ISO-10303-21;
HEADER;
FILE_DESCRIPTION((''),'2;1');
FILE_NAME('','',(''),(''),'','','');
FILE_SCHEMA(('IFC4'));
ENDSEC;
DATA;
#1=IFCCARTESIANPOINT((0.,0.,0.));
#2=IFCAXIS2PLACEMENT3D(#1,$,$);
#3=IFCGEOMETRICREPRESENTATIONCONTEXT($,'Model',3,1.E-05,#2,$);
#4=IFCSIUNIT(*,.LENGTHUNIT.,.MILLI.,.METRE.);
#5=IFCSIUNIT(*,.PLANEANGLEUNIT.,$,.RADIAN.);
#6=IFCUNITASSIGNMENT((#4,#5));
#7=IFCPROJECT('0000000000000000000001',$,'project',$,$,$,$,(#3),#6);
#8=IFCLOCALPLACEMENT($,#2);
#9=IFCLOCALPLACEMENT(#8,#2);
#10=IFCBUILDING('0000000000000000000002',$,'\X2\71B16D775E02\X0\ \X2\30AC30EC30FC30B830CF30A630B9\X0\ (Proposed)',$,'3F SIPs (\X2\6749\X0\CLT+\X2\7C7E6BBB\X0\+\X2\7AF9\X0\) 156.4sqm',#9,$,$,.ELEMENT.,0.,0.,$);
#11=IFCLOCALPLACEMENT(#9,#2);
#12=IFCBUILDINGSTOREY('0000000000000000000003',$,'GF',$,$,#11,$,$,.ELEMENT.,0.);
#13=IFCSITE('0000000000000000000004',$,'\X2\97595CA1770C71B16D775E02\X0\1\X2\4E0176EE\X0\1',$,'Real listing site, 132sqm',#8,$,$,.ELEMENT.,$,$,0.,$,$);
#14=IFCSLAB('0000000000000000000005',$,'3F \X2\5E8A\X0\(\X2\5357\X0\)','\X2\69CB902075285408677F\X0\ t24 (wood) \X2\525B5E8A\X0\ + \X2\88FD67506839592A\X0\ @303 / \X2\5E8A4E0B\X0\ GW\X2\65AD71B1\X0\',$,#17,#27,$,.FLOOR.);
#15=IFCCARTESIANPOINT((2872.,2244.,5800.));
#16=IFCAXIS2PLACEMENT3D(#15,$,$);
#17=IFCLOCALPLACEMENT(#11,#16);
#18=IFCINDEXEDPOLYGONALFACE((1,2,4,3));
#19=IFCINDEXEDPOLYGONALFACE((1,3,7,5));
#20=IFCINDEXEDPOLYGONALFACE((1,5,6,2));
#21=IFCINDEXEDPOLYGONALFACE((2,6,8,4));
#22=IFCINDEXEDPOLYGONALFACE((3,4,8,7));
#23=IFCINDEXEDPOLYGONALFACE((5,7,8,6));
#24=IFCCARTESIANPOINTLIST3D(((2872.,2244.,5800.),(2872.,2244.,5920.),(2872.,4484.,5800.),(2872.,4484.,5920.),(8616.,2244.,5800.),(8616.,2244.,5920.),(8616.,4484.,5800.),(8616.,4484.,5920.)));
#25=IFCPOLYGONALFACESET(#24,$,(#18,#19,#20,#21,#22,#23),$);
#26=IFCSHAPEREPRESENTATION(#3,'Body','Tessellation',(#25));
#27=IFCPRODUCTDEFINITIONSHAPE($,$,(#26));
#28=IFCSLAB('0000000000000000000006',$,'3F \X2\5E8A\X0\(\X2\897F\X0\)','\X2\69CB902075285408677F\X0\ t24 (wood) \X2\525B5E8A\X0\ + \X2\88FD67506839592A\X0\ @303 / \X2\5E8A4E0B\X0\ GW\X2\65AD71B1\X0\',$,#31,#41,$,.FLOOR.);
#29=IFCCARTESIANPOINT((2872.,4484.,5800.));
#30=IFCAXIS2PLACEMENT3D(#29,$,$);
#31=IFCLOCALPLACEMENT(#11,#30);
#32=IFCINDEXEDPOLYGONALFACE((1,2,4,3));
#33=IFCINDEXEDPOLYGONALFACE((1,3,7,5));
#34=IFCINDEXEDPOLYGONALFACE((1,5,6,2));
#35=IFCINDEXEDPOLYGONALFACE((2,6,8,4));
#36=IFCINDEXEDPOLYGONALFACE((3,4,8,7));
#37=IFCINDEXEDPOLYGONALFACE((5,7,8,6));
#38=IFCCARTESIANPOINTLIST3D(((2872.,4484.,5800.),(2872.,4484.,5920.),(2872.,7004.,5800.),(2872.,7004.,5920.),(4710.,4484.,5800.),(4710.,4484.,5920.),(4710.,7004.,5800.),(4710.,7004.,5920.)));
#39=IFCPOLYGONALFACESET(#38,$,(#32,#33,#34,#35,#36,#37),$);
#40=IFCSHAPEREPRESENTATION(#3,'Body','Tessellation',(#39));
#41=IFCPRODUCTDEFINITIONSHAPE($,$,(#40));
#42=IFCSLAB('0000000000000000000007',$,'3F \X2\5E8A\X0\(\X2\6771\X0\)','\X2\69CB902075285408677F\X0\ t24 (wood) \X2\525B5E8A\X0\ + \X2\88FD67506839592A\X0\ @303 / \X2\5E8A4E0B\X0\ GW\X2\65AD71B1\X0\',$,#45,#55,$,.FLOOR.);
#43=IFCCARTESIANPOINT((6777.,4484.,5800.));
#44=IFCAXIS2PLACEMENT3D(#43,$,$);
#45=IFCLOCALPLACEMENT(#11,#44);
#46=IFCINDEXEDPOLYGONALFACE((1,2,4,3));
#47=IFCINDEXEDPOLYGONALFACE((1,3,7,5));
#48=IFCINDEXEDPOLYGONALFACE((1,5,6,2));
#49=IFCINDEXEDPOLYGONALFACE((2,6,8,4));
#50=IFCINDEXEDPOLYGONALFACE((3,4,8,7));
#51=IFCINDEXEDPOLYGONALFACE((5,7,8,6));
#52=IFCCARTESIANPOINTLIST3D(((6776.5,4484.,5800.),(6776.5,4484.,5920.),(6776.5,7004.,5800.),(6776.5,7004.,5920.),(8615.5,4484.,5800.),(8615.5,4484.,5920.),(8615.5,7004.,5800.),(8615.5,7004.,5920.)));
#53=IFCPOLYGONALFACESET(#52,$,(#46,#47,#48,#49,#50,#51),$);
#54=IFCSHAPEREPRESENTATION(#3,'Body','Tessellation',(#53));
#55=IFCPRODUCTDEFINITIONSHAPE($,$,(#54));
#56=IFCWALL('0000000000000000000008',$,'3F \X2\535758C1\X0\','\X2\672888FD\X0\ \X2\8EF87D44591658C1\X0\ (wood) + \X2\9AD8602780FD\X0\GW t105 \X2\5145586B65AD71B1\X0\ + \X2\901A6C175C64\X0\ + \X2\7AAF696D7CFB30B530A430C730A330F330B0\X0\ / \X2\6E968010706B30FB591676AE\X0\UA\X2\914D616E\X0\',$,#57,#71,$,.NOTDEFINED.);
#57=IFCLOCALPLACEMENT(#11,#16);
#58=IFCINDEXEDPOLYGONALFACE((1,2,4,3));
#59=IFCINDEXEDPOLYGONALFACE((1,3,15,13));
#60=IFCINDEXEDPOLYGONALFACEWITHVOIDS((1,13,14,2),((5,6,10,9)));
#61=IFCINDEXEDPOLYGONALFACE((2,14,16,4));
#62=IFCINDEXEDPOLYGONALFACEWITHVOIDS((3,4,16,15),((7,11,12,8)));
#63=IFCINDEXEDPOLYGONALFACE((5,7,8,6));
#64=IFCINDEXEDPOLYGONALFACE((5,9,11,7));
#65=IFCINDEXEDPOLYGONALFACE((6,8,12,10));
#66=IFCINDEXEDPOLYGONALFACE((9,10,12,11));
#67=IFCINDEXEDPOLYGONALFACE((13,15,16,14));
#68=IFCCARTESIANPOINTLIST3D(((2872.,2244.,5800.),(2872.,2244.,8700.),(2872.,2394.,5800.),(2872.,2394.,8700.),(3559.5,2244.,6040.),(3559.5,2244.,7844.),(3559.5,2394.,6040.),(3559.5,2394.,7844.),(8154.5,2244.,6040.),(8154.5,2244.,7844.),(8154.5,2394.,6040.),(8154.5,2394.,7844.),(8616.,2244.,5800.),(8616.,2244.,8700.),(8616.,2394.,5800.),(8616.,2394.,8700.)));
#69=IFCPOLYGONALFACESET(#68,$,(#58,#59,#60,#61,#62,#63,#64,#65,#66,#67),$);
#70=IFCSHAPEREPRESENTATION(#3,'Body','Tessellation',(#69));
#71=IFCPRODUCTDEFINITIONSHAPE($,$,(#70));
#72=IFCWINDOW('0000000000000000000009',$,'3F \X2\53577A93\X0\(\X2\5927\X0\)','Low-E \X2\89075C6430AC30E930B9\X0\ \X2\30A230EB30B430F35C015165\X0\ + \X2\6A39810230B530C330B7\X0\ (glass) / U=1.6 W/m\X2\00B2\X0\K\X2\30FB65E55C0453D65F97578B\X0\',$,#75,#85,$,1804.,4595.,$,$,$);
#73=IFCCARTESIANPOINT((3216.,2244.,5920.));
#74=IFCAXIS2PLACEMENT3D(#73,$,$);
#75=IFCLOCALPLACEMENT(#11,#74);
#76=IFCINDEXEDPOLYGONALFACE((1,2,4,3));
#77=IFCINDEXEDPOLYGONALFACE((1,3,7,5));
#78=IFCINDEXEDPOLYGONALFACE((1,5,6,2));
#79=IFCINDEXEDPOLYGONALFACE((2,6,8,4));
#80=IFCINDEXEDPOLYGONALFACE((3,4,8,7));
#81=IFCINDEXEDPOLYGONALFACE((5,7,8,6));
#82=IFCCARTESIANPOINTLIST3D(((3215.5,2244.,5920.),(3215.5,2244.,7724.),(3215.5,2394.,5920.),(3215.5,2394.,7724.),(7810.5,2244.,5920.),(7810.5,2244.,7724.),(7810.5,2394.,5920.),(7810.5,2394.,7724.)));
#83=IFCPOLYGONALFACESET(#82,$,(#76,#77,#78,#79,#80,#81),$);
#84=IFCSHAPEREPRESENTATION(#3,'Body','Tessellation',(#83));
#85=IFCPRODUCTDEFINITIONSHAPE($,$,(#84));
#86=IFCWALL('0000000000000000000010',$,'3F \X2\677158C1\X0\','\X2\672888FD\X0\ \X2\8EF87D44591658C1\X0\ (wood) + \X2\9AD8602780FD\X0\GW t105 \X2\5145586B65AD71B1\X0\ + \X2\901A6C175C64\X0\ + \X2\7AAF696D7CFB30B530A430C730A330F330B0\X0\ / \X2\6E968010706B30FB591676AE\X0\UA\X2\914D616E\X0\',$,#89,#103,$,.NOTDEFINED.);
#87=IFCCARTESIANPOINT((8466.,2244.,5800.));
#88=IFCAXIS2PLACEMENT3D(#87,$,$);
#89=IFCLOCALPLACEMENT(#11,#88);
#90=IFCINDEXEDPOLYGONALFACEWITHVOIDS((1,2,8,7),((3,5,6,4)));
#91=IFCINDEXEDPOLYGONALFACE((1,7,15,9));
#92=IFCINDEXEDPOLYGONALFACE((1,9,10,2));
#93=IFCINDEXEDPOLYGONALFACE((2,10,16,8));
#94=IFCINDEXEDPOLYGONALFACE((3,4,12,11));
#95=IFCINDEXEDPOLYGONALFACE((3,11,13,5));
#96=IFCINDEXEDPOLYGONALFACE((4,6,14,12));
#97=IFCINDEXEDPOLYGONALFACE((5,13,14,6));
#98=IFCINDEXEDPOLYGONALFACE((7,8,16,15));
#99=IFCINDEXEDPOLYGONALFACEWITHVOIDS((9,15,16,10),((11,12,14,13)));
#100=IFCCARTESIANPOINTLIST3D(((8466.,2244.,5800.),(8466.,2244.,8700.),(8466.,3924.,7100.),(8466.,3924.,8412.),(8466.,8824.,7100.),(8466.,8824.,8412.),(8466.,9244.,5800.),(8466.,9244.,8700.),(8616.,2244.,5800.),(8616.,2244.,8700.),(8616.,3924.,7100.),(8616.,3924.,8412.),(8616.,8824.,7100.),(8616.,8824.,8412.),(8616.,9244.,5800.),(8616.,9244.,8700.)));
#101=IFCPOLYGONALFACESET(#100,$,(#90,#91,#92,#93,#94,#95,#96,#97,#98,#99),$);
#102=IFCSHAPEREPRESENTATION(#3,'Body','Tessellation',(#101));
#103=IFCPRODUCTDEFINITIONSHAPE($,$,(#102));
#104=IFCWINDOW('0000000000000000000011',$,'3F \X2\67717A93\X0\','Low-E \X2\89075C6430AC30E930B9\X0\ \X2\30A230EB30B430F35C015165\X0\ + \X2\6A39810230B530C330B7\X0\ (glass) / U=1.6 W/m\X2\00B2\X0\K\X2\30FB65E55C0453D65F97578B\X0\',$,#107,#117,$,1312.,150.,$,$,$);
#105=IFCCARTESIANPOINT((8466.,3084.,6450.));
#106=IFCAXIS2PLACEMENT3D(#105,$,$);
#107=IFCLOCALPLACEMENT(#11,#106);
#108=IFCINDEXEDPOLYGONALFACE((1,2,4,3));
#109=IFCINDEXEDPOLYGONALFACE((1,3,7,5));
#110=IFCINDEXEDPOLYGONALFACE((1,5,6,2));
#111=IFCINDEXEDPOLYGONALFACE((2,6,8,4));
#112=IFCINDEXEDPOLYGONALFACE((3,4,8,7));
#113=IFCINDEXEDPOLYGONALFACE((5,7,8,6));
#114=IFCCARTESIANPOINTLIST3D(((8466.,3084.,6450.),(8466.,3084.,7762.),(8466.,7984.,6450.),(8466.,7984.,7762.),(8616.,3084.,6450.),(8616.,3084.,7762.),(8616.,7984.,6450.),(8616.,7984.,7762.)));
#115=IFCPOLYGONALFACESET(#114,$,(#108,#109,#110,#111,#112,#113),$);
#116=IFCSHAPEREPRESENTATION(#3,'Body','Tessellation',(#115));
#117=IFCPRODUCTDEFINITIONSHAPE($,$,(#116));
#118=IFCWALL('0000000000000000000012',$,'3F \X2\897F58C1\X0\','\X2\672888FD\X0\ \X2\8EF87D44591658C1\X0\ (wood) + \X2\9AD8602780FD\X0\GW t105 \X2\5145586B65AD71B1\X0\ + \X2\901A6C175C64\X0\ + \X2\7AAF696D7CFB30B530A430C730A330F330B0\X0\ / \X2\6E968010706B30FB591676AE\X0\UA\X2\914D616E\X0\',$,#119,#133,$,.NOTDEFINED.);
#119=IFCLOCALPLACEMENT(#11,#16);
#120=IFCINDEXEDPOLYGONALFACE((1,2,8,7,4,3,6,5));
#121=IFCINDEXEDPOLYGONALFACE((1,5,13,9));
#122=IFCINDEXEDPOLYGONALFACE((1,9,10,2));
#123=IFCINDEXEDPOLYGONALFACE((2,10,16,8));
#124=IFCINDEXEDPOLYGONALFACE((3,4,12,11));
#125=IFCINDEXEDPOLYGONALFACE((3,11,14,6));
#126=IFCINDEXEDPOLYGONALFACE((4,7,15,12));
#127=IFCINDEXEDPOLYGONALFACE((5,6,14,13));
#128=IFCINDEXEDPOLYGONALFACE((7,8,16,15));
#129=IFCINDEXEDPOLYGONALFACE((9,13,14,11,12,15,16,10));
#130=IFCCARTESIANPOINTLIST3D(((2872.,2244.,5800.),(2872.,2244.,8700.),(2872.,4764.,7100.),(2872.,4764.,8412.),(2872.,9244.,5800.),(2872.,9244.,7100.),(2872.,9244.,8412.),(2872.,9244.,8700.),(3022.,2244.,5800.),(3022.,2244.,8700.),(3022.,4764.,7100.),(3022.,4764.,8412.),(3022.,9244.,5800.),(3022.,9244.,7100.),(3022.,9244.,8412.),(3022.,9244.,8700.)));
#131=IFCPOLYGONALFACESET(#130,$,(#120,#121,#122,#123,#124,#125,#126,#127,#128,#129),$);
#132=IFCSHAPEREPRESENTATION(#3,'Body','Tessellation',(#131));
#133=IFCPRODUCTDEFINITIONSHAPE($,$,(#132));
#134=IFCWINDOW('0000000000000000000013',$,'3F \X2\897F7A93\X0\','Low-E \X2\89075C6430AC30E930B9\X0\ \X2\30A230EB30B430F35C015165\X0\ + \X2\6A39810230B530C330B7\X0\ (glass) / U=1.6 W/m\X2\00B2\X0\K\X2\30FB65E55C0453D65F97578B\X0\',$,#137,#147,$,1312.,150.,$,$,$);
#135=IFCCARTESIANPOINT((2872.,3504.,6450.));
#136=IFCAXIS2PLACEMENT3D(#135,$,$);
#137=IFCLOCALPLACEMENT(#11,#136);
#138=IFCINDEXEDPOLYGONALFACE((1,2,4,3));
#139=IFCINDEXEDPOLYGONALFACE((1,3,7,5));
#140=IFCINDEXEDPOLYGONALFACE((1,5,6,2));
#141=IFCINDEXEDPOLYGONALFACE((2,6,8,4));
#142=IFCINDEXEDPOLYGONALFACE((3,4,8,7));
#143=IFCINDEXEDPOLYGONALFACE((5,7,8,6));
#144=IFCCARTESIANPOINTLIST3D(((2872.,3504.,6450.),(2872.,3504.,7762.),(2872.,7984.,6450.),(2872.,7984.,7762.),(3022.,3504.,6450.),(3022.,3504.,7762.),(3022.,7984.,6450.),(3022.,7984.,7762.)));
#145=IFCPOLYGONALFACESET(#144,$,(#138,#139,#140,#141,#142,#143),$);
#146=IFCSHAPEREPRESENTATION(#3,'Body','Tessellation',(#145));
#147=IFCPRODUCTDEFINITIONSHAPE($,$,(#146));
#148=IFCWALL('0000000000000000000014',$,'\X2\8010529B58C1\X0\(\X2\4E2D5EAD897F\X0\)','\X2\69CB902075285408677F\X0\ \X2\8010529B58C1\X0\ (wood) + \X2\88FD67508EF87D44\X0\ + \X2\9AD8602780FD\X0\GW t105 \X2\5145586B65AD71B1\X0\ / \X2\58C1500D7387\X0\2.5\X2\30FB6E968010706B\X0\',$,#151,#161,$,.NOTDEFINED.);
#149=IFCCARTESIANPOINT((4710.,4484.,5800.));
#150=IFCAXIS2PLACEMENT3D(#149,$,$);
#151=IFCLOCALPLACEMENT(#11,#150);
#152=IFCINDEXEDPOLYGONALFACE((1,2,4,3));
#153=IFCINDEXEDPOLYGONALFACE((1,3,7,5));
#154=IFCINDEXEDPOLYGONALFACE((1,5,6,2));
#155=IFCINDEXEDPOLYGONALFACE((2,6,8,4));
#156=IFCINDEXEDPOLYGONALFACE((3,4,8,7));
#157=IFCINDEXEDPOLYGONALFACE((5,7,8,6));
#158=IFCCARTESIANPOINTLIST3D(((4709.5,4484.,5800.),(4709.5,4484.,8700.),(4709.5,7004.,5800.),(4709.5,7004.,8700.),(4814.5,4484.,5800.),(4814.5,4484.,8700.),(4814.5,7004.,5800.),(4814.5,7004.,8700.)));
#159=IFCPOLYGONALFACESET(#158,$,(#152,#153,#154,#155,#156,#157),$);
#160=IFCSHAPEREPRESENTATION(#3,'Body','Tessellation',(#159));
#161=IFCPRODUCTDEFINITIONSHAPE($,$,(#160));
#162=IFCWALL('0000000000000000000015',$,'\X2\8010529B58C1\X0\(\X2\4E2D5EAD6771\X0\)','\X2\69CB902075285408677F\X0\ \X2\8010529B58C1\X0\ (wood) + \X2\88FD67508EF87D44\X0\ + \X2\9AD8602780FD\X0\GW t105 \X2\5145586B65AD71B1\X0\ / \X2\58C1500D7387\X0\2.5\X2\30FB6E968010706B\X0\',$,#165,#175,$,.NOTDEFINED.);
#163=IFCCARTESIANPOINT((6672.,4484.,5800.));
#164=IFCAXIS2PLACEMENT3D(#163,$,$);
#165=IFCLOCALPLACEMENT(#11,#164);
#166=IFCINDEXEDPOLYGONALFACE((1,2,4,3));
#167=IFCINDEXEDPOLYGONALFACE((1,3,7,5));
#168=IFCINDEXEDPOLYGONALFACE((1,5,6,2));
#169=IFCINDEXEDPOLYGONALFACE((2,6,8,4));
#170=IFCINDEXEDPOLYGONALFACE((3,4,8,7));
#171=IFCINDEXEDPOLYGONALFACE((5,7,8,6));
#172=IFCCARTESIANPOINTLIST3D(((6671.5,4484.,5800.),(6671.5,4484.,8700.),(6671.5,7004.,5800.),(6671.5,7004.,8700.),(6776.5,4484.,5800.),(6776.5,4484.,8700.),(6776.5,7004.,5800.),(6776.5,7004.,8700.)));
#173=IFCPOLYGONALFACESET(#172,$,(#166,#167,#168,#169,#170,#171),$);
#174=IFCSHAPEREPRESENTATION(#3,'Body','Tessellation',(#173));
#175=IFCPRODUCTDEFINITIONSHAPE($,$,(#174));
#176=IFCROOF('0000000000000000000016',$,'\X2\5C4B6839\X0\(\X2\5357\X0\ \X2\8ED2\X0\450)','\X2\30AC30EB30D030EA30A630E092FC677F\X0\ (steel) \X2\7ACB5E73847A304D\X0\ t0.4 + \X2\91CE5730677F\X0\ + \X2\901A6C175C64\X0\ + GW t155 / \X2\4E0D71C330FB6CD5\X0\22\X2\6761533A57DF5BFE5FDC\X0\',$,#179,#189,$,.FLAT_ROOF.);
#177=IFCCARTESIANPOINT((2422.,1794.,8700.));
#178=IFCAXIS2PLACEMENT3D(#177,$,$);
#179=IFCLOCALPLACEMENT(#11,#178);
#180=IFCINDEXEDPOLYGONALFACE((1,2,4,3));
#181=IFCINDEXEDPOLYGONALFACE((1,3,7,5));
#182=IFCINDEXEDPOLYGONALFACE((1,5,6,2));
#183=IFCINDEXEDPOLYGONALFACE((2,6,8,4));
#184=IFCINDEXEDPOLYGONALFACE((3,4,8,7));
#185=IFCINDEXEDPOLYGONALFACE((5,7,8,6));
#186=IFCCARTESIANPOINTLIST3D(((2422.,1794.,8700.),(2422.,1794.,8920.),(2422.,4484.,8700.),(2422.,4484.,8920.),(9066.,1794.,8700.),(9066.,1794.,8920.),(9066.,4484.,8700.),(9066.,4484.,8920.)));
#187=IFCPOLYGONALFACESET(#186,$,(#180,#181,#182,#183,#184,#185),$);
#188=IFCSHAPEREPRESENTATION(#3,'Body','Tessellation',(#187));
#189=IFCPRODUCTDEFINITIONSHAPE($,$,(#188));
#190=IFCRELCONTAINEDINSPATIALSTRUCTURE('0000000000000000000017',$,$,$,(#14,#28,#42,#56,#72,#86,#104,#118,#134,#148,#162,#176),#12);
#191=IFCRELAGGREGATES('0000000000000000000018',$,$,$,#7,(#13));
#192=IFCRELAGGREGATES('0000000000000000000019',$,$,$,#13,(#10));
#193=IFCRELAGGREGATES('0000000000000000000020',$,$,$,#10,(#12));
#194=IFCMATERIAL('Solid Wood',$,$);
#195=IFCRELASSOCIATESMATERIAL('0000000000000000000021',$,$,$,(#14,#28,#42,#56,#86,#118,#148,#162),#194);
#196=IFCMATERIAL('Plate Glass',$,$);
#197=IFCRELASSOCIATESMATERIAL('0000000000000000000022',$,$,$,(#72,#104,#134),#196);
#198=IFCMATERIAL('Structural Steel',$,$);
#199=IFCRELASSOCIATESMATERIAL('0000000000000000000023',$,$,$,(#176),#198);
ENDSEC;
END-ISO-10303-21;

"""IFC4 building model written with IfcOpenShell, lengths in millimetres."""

from ifc_helpers import new_model, si_unit, frame, frame_2d, origin, place, context, project, spatial, rectangle, extrude, material, element, fill, save


model = new_model("IFC4")

# Units and contexts
model_context = context("Model", 3, precision=1e-05, world=origin())
ifc_project = project(units=[si_unit("LENGTHUNIT", "METRE", prefix="MILLI"), si_unit("PLANEANGLEUNIT", "RADIAN")], contexts=[model_context])

# Site, building, storey
site_placement = place(None, origin())
site = spatial("IfcSite", under=ifc_project, at=site_placement, Name="静岡県熱海市1丁目1", ObjectType="Real listing site, 132sqm", CompositionType="ELEMENT", RefElevation=0.0)
building_placement = place(site_placement, origin())
building = spatial("IfcBuilding", under=site, at=building_placement, Name="熱海市 ガレージハウス (Proposed)", ObjectType="3F SIPs (杉CLT+籾殻+竹) 156.4sqm", CompositionType="ELEMENT", ElevationOfRefHeight=0.0, ElevationOfTerrain=0.0)
storey_placement = place(building_placement, origin())
storey = spatial("IfcBuildingStorey", under=building, at=storey_placement, Name="GF", CompositionType="ELEMENT", Elevation=0.0)

# Slabs
ifc_material_1 = material(Name="Solid Wood")
slab_1_placement = place(storey_placement, frame((2872.0, 2244.0, 5800.0)))
element("IfcSlab", 1, at=slab_1_placement, inside=storey, material=ifc_material_1, Name="3F 床(南)", Description="構造用合板 t24 (wood) 剛床 + 製材根太 @303 / 床下 GW断熱", PredefinedType="FLOOR", context=model_context, shape_type="SweptSolid", body=[
    extrude(rectangle(XDim=5744.0, YDim=2240.0, at=frame_2d((2872.0, 1120.0))), frame((2872.0, 2244.0, 5800.0)), (0.0, 0.0, 1.0), 120.0),
])
slab_2_placement = place(storey_placement, frame((2872.0, 4484.0, 5800.0)))
element("IfcSlab", 2, at=slab_2_placement, inside=storey, material=ifc_material_1, Name="3F 床(西)", Description="構造用合板 t24 (wood) 剛床 + 製材根太 @303 / 床下 GW断熱", PredefinedType="FLOOR", context=model_context, shape_type="SweptSolid", body=[
    extrude(rectangle(XDim=1838.0, YDim=2520.0, at=frame_2d((919.0, 1260.0))), frame((2872.0, 4484.0, 5800.0)), (0.0, 0.0, 1.0), 120.0),
])
slab_3_placement = place(storey_placement, frame((6777.0, 4484.0, 5800.0)))
element("IfcSlab", 3, at=slab_3_placement, inside=storey, material=ifc_material_1, Name="3F 床(東)", Description="構造用合板 t24 (wood) 剛床 + 製材根太 @303 / 床下 GW断熱", PredefinedType="FLOOR", context=model_context, shape_type="SweptSolid", body=[
    extrude(rectangle(XDim=1839.0, YDim=2520.0, at=frame_2d((919.0, 1260.0))), frame((6777.0, 4484.0, 5800.0)), (0.0, 0.0, 1.0), 120.0),
])

# Walls, openings, windows
wall_1_placement = place(storey_placement, frame((2872.0, 2244.0, 5800.0)))
wall_1 = element("IfcWall", 4, at=wall_1_placement, inside=storey, material=ifc_material_1, Name="3F 南壁", Description="木製 軸組外壁 (wood) + 高性能GW t105 充填断熱 + 通気層 + 窯業系サイディング / 準耐火・外皮UA配慮", PredefinedType="NOTDEFINED", context=model_context, shape_type="SweptSolid", body=[
    extrude(rectangle(XDim=5744.0, YDim=150.0, at=frame_2d((2872.0, 75.0))), frame((2872.0, 2244.0, 5800.0)), (0.0, 0.0, 1.0), 2900.0),
])
opening_1_placement = place(storey_placement, frame((3216.0, 2244.0, 5920.0)))
opening_1 = element("IfcOpeningElement", 5, at=opening_1_placement, cuts=wall_1, PredefinedType="NOTDEFINED", context=model_context, shape_type="SweptSolid", body=[
    extrude(rectangle(XDim=4595.0, YDim=150.0, at=frame_2d((2297.0, 75.0))), frame((3216.0, 2244.0, 5920.0)), (0.0, 0.0, 1.0), 1804.0),
])
ifc_material_2 = material(Name="Plate Glass")
window_1_placement = place(storey_placement, frame((3216.0, 2244.0, 5920.0)))
window_1 = element("IfcWindow", 6, at=window_1_placement, inside=storey, material=ifc_material_2, Name="3F 南窓(大)", Description="Low-E 複層ガラス アルゴン封入 + 樹脂サッシ (glass) / U=1.6 W/m²K・日射取得型", OverallHeight=1804.0, OverallWidth=4595.0, context=model_context, shape_type="SweptSolid", body=[
    extrude(rectangle(XDim=4595.0, YDim=150.0, at=frame_2d((2297.0, 75.0))), frame((3216.0, 2244.0, 5920.0)), (0.0, 0.0, 1.0), 1804.0),
])
fill(opening_1, window_1)
wall_2_placement = place(storey_placement, frame((8466.0, 2244.0, 5800.0)))
wall_2 = element("IfcWall", 7, at=wall_2_placement, inside=storey, material=ifc_material_1, Name="3F 東壁", Description="木製 軸組外壁 (wood) + 高性能GW t105 充填断熱 + 通気層 + 窯業系サイディング / 準耐火・外皮UA配慮", PredefinedType="NOTDEFINED", context=model_context, shape_type="SweptSolid", body=[
    extrude(rectangle(XDim=150.0, YDim=7000.0, at=frame_2d((75.0, 3500.0))), frame((8466.0, 2244.0, 5800.0)), (0.0, 0.0, 1.0), 2900.0),
])
opening_2_placement = place(storey_placement, frame((8466.0, 3084.0, 6450.0)))
opening_2 = element("IfcOpeningElement", 8, at=opening_2_placement, cuts=wall_2, PredefinedType="NOTDEFINED", context=model_context, shape_type="SweptSolid", body=[
    extrude(rectangle(XDim=150.0, YDim=4900.0, at=frame_2d((75.0, 2450.0))), frame((8466.0, 3084.0, 6450.0)), (0.0, 0.0, 1.0), 1312.0),
])
window_2_placement = place(storey_placement, frame((8466.0, 3084.0, 6450.0)))
window_2 = element("IfcWindow", 9, at=window_2_placement, inside=storey, material=ifc_material_2, Name="3F 東窓", Description="Low-E 複層ガラス アルゴン封入 + 樹脂サッシ (glass) / U=1.6 W/m²K・日射取得型", OverallHeight=1312.0, OverallWidth=150.0, context=model_context, shape_type="SweptSolid", body=[
    extrude(rectangle(XDim=150.0, YDim=4900.0, at=frame_2d((75.0, 2450.0))), frame((8466.0, 3084.0, 6450.0)), (0.0, 0.0, 1.0), 1312.0),
])
fill(opening_2, window_2)
wall_3_placement = place(storey_placement, frame((2872.0, 2244.0, 5800.0)))
wall_3 = element("IfcWall", 10, at=wall_3_placement, inside=storey, material=ifc_material_1, Name="3F 西壁", Description="木製 軸組外壁 (wood) + 高性能GW t105 充填断熱 + 通気層 + 窯業系サイディング / 準耐火・外皮UA配慮", PredefinedType="NOTDEFINED", context=model_context, shape_type="SweptSolid", body=[
    extrude(rectangle(XDim=150.0, YDim=7000.0, at=frame_2d((75.0, 3500.0))), frame((2872.0, 2244.0, 5800.0)), (0.0, 0.0, 1.0), 2900.0),
])
opening_3_placement = place(storey_placement, frame((2872.0, 3504.0, 6450.0)))
opening_3 = element("IfcOpeningElement", 11, at=opening_3_placement, cuts=wall_3, PredefinedType="NOTDEFINED", context=model_context, shape_type="SweptSolid", body=[
    extrude(rectangle(XDim=150.0, YDim=4480.0, at=frame_2d((75.0, 2240.0))), frame((2872.0, 3504.0, 6450.0)), (0.0, 0.0, 1.0), 1312.0),
])
window_3_placement = place(storey_placement, frame((2872.0, 3504.0, 6450.0)))
window_3 = element("IfcWindow", 12, at=window_3_placement, inside=storey, material=ifc_material_2, Name="3F 西窓", Description="Low-E 複層ガラス アルゴン封入 + 樹脂サッシ (glass) / U=1.6 W/m²K・日射取得型", OverallHeight=1312.0, OverallWidth=150.0, context=model_context, shape_type="SweptSolid", body=[
    extrude(rectangle(XDim=150.0, YDim=4480.0, at=frame_2d((75.0, 2240.0))), frame((2872.0, 3504.0, 6450.0)), (0.0, 0.0, 1.0), 1312.0),
])
fill(opening_3, window_3)

# Walls
wall_4_placement = place(storey_placement, frame((4710.0, 4484.0, 5800.0)))
element("IfcWall", 13, at=wall_4_placement, inside=storey, material=ifc_material_1, Name="耐力壁(中庭西)", Description="構造用合板 耐力壁 (wood) + 製材軸組 + 高性能GW t105 充填断熱 / 壁倍率2.5・準耐火", PredefinedType="NOTDEFINED", context=model_context, shape_type="SweptSolid", body=[
    extrude(rectangle(XDim=105.0, YDim=2520.0, at=frame_2d((52.0, 1260.0))), frame((4710.0, 4484.0, 5800.0)), (0.0, 0.0, 1.0), 2900.0),
])
wall_5_placement = place(storey_placement, frame((6672.0, 4484.0, 5800.0)))
element("IfcWall", 14, at=wall_5_placement, inside=storey, material=ifc_material_1, Name="耐力壁(中庭東)", Description="構造用合板 耐力壁 (wood) + 製材軸組 + 高性能GW t105 充填断熱 / 壁倍率2.5・準耐火", PredefinedType="NOTDEFINED", context=model_context, shape_type="SweptSolid", body=[
    extrude(rectangle(XDim=105.0, YDim=2520.0, at=frame_2d((52.0, 1260.0))), frame((6672.0, 4484.0, 5800.0)), (0.0, 0.0, 1.0), 2900.0),
])

# Roof
ifc_material_3 = material(Name="Structural Steel")
roof_1_placement = place(storey_placement, frame((2422.0, 1794.0, 8700.0)))
element("IfcRoof", 15, at=roof_1_placement, inside=storey, material=ifc_material_3, Name="屋根(南 軒450)", Description="ガルバリウム鋼板 (steel) 立平葺き t0.4 + 野地板 + 通気層 + GW t155 / 不燃・法22条区域対応", PredefinedType="FLAT_ROOF", context=model_context, shape_type="SweptSolid", body=[
    extrude(rectangle(XDim=6644.0, YDim=2690.0, at=frame_2d((3322.0, 1345.0))), frame((2422.0, 1794.0, 8700.0)), (0.0, 0.0, 1.0), 220.0),
])

save(model, "model.ifc")
